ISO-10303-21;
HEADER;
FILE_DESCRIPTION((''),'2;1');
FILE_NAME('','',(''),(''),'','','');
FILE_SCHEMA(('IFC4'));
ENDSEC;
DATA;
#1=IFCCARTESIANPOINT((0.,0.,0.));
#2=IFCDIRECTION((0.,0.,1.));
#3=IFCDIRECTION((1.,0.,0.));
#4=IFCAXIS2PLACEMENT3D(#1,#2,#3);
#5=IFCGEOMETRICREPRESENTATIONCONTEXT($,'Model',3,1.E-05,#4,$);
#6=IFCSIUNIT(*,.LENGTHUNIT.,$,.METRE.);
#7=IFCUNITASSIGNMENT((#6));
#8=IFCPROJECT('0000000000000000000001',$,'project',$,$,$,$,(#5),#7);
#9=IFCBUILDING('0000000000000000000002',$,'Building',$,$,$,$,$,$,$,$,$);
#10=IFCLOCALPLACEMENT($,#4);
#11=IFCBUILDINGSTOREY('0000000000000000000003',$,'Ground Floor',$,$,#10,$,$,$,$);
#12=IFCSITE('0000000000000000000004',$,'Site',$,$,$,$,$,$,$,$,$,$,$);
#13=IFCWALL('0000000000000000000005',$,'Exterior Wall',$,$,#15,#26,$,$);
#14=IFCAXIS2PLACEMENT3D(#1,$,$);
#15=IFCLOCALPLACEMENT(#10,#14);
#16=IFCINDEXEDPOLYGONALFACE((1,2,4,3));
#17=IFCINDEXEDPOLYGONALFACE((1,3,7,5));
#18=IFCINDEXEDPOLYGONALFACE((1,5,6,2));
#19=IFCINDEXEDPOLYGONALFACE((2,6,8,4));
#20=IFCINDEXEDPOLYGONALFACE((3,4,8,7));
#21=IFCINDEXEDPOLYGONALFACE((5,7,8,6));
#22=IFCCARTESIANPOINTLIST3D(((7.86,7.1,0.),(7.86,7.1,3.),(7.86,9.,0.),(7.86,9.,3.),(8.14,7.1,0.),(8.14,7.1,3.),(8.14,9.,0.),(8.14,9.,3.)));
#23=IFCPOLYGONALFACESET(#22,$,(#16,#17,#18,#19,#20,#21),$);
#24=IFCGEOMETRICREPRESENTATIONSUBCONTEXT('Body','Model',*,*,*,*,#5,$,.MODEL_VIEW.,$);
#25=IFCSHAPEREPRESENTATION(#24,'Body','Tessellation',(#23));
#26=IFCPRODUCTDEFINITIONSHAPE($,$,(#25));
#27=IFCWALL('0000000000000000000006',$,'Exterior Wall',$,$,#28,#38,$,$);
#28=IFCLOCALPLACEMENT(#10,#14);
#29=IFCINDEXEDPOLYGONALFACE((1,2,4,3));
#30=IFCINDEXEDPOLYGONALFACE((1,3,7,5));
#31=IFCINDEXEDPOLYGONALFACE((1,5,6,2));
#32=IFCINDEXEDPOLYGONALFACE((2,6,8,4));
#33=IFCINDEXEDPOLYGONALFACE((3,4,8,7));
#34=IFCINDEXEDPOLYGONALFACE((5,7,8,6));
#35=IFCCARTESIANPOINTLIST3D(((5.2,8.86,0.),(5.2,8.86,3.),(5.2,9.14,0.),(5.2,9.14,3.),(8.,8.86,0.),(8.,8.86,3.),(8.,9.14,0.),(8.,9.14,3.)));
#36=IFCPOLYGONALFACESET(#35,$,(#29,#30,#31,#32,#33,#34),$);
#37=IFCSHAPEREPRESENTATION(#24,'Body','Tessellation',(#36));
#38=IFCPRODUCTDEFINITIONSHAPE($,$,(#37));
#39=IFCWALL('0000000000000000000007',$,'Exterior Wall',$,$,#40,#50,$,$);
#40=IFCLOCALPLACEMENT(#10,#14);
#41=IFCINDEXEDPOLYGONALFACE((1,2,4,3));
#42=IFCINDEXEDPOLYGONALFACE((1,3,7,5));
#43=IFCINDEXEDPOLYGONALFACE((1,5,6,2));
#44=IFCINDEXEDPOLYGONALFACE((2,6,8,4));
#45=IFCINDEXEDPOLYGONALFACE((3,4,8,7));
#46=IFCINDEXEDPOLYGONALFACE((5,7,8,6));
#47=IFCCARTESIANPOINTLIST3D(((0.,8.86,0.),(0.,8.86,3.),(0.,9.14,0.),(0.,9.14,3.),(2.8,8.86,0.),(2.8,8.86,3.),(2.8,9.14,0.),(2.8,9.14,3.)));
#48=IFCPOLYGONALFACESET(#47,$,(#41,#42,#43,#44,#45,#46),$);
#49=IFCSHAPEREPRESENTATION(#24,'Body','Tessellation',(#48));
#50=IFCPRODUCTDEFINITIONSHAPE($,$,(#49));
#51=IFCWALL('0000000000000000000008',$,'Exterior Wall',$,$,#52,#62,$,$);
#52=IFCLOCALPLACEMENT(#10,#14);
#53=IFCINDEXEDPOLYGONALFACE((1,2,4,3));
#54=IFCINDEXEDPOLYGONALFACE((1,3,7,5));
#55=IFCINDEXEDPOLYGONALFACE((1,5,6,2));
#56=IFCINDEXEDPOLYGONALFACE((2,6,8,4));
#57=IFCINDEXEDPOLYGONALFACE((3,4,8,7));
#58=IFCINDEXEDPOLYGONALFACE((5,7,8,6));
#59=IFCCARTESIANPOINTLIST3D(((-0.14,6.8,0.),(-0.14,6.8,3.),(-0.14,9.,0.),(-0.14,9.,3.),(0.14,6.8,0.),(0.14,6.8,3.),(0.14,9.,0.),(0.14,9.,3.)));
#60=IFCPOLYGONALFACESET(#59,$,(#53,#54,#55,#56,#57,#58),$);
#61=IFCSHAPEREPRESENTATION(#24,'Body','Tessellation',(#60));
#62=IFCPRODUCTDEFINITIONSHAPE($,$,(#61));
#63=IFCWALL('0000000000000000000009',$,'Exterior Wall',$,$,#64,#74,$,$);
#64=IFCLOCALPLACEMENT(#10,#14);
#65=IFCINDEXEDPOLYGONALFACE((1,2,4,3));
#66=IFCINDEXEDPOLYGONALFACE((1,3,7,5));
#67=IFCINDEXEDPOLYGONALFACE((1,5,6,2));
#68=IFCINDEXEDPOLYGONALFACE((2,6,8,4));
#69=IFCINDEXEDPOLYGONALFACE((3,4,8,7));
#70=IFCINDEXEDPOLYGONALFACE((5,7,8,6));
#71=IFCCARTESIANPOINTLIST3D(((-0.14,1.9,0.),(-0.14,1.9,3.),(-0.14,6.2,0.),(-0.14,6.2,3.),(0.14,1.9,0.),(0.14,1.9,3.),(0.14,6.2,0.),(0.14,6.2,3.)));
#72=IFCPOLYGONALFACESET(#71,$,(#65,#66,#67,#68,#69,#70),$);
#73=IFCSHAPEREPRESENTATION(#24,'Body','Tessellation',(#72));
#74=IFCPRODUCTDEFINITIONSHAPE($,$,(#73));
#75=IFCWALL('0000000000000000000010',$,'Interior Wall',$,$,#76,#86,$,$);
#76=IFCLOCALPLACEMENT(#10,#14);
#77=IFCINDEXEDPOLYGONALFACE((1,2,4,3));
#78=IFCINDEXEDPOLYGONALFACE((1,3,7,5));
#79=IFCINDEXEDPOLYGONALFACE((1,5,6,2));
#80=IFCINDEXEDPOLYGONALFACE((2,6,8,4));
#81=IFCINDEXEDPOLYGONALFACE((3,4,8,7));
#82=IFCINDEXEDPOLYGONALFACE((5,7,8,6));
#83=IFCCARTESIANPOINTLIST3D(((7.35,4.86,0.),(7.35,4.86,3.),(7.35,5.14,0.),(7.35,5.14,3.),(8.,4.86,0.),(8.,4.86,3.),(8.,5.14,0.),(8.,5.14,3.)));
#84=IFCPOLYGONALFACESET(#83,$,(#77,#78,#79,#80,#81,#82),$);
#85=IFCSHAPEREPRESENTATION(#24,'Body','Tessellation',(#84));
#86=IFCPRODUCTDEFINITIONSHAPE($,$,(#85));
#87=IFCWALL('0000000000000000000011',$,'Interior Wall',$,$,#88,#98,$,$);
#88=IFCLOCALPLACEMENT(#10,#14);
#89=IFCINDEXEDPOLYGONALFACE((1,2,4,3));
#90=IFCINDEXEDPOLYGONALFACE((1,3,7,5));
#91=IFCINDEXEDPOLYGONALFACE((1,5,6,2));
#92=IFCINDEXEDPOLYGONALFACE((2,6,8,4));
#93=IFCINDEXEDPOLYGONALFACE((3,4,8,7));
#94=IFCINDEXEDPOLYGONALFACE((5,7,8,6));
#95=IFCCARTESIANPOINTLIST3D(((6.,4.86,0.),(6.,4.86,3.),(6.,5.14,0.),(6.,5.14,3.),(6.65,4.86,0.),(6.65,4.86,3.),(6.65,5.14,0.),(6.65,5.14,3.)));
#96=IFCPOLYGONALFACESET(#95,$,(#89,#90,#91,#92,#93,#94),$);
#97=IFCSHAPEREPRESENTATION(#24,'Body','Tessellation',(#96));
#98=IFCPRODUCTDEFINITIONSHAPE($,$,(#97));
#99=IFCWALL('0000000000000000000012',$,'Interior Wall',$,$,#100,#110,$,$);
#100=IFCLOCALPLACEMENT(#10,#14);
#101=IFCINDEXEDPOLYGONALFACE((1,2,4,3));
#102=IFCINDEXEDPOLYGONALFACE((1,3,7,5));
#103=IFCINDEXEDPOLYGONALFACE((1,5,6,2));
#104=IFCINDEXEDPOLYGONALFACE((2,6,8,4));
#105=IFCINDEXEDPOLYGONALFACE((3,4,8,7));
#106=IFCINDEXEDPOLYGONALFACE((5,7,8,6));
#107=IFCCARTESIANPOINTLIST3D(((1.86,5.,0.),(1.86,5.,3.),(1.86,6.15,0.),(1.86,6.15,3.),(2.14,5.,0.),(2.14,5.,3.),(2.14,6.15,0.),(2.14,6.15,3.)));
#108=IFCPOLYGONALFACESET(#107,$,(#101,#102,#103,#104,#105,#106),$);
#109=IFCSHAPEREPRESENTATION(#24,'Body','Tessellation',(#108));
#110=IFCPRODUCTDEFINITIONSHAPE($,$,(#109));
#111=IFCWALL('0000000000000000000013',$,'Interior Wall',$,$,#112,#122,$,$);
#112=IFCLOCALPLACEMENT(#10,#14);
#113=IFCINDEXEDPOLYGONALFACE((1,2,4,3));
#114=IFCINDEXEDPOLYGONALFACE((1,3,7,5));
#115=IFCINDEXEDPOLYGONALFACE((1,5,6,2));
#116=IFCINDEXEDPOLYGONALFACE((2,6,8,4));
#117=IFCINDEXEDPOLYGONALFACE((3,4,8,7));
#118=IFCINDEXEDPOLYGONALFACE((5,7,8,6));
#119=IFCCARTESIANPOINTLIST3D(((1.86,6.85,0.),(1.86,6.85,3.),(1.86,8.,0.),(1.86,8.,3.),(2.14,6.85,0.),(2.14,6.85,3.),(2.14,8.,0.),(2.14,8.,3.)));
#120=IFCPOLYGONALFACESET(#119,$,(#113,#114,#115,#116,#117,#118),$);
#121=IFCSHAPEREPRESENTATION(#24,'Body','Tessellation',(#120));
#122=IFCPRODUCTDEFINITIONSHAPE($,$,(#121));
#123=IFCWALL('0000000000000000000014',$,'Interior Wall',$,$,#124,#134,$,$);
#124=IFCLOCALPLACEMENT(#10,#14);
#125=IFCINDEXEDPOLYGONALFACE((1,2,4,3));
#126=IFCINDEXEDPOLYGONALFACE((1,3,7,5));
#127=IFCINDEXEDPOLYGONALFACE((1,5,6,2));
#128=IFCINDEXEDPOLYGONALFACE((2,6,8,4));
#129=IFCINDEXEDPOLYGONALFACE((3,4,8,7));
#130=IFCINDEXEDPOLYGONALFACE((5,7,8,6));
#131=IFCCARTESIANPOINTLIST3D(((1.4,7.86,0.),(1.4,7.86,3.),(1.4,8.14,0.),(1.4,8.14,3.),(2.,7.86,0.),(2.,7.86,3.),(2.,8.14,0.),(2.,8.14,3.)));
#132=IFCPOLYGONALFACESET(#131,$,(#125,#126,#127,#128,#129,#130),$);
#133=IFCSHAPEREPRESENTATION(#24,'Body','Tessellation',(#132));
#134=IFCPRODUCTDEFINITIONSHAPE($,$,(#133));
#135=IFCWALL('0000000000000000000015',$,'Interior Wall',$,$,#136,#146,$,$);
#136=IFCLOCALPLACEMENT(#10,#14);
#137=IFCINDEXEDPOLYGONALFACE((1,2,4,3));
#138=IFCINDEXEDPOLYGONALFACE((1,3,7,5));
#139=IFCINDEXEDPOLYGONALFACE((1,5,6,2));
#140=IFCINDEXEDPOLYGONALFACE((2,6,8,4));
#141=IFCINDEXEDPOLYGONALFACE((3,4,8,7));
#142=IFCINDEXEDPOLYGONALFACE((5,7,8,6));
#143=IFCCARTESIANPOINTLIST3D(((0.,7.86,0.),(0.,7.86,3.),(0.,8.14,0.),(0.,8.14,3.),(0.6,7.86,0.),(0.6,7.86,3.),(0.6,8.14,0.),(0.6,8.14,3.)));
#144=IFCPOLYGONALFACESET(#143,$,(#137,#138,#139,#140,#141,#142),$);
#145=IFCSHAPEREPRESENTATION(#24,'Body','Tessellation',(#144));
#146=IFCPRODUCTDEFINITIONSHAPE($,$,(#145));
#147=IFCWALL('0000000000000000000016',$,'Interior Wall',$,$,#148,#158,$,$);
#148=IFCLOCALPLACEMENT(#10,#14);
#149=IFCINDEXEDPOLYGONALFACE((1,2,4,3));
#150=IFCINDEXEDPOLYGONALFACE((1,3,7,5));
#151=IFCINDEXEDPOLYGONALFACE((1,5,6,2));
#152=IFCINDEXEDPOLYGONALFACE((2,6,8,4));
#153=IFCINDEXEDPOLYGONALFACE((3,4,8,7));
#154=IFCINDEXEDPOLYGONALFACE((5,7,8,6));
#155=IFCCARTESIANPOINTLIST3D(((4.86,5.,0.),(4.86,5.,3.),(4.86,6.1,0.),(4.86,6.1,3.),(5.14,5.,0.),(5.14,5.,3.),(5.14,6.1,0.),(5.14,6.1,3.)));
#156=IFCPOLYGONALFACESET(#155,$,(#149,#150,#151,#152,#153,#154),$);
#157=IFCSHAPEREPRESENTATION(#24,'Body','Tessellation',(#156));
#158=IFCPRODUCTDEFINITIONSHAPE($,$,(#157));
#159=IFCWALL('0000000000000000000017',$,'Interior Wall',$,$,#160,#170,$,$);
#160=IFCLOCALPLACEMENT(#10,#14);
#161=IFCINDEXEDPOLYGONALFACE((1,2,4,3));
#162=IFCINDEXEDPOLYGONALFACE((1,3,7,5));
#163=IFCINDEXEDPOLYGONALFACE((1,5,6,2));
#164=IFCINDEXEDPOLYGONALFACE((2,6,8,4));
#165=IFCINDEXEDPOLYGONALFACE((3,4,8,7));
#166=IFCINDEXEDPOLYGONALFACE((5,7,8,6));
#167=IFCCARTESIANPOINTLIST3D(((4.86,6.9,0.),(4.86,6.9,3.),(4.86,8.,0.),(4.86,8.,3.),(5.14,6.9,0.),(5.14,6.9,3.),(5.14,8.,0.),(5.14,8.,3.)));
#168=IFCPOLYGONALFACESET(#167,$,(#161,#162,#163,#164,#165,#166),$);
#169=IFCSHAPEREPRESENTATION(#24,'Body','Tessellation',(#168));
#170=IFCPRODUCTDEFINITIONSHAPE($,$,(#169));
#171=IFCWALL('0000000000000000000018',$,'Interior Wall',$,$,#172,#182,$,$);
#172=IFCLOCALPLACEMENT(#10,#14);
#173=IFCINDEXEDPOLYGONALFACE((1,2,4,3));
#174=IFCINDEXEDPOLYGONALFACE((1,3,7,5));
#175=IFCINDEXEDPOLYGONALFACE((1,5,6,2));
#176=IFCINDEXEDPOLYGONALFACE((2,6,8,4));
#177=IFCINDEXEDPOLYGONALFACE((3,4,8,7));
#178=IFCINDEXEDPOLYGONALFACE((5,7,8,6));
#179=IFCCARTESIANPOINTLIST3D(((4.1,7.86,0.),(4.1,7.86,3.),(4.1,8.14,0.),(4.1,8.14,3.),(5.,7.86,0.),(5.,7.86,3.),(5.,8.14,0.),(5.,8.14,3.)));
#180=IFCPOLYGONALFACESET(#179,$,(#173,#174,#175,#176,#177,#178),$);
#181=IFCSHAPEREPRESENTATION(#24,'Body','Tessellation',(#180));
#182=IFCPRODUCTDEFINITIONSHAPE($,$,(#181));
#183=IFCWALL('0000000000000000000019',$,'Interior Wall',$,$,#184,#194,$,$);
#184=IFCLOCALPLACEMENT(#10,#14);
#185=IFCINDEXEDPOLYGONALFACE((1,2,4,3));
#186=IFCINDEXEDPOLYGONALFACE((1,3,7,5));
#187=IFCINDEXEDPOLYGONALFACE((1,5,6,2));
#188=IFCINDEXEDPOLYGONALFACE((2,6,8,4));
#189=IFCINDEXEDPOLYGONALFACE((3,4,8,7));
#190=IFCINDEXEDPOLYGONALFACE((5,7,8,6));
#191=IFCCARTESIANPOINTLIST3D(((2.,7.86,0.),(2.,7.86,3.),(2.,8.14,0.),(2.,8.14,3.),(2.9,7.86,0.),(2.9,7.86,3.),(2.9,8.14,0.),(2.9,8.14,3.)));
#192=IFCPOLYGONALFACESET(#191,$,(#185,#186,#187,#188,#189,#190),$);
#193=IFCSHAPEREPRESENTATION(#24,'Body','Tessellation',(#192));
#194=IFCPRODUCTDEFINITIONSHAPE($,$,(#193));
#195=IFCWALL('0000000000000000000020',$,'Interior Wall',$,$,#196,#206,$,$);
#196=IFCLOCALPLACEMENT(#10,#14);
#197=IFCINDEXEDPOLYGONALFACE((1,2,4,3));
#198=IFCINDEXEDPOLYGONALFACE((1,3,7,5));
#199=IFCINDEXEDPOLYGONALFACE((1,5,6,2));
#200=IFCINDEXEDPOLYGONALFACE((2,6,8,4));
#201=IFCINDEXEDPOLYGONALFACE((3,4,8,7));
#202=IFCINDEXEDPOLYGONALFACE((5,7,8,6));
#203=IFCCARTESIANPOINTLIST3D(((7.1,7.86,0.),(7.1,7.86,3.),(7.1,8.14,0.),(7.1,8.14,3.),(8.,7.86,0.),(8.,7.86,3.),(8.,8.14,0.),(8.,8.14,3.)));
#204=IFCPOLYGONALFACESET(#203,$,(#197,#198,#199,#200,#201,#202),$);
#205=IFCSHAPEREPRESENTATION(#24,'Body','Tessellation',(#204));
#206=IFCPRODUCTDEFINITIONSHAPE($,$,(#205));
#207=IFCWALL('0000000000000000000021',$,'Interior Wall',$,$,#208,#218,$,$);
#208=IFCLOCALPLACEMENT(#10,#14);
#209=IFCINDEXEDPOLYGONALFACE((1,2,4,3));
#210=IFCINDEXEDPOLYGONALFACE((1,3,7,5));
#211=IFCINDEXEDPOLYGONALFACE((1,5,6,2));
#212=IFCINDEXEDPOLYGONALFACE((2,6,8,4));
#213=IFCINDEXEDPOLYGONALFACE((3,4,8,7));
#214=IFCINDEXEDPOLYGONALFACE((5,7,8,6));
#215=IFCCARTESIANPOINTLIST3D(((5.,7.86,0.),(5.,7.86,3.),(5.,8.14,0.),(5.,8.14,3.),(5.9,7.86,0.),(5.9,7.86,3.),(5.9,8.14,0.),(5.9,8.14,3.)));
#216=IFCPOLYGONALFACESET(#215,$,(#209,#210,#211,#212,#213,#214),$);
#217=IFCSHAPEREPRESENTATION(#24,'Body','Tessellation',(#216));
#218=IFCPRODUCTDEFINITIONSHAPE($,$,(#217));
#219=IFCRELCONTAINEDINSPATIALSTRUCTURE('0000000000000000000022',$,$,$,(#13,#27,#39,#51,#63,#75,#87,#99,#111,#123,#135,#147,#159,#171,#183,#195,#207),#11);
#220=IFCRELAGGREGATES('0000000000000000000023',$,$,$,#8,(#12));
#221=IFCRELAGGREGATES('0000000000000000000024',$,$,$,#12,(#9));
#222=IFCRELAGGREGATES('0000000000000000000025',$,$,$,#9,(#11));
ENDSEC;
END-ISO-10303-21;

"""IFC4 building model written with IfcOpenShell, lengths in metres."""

from ifc_helpers import new_model, si_unit, frame, origin_with_axes, place, context, subcontext, project, spatial, indexed_curve, outline, extrude, element, save


model = new_model("IFC4")

# Units and contexts
model_context = context("Model", 3, precision=1e-05, world=origin_with_axes())
body_context = subcontext(model_context, "Body", "Model", "MODEL_VIEW")
ifc_project = project(units=[si_unit("LENGTHUNIT", "METRE")], contexts=[model_context])

# Site, building, storey
site = spatial("IfcSite", under=ifc_project, Name="Site")
building = spatial("IfcBuilding", under=site, Name="Building")
storey_placement = place(None, origin_with_axes())
storey = spatial("IfcBuildingStorey", under=building, at=storey_placement, Name="Ground Floor")

# Walls
wall_1_placement = place(storey_placement, frame((8.0, 7.1, 0.0), z_axis=(0.0, 0.0, 1.0), x_axis=(0.0, 1.0, 0.0)))
element("IfcWall", 1, at=wall_1_placement, inside=storey, Name="Exterior Wall", context=body_context, shape_type="SweptSolid", body=[
    extrude(outline(indexed_curve([(0.0, 0.0), (0.0, 0.28), (1.9, 0.28), (1.9, 0.0), (0.0, 0.0)], self_intersect=False)), frame((0.0, -0.14, 0.0), z_axis=(0.0, 0.0, 1.0), x_axis=(1.0, 0.0, 0.0)), (0.0, 0.0, 1.0), 3.0),
])
for number, where, z_axis, x_axis, name in (
    (2, (8.0, 9.0, 0.0), (0.0, 0.0, 1.0), (-1.0, 0.0, 0.0), "Exterior Wall"),
    (3, (2.8, 9.0, 0.0), (0.0, 0.0, 1.0), (-1.0, 0.0, 0.0), "Exterior Wall"),
):
    element("IfcWall", number, at=place(storey_placement, frame(where, z_axis=z_axis, x_axis=x_axis)), inside=storey, Name=name, context=body_context, shape_type="SweptSolid", body=[
        extrude(outline(indexed_curve([(0.0, 0.0), (0.0, 0.28), (2.8, 0.28), (2.8, 0.0), (0.0, 0.0)], self_intersect=False)), frame((0.0, -0.14, 0.0), z_axis=(0.0, 0.0, 1.0), x_axis=(1.0, 0.0, 0.0)), (0.0, 0.0, 1.0), 3.0),
    ])
wall_2_placement = place(storey_placement, frame((0.0, 9.0, 0.0), z_axis=(0.0, 0.0, 1.0), x_axis=(0.0, -1.0, 0.0)))
element("IfcWall", 4, at=wall_2_placement, inside=storey, Name="Exterior Wall", context=body_context, shape_type="SweptSolid", body=[
    extrude(outline(indexed_curve([(0.0, 0.0), (0.0, 0.28), (2.2, 0.28), (2.2, 0.0), (0.0, 0.0)], self_intersect=False)), frame((0.0, -0.14, 0.0), z_axis=(0.0, 0.0, 1.0), x_axis=(1.0, 0.0, 0.0)), (0.0, 0.0, 1.0), 3.0),
])
wall_3_placement = place(storey_placement, frame((0.0, 6.2, 0.0), z_axis=(0.0, 0.0, 1.0), x_axis=(0.0, -1.0, 0.0)))
element("IfcWall", 5, at=wall_3_placement, inside=storey, Name="Exterior Wall", context=body_context, shape_type="SweptSolid", body=[
    extrude(outline(indexed_curve([(0.0, 0.0), (0.0, 0.28), (4.3, 0.28), (4.3, 0.0), (0.0, 0.0)], self_intersect=False)), frame((0.0, -0.14, 0.0), z_axis=(0.0, 0.0, 1.0), x_axis=(1.0, 0.0, 0.0)), (0.0, 0.0, 1.0), 3.0),
])
for number, where, z_axis, x_axis, name in (
    (6, (8.0, 5.0, 0.0), (0.0, 0.0, 1.0), (-1.0, 0.0, 0.0), "Interior Wall"),
    (7, (6.65, 5.0, 0.0), (0.0, 0.0, 1.0), (-1.0, 0.0, 0.0), "Interior Wall"),
):
    element("IfcWall", number, at=place(storey_placement, frame(where, z_axis=z_axis, x_axis=x_axis)), inside=storey, Name=name, context=body_context, shape_type="SweptSolid", body=[
        extrude(outline(indexed_curve([(0.0, 0.0), (0.0, 0.28), (0.65, 0.28), (0.65, 0.0), (0.0, 0.0)], self_intersect=False)), frame((0.0, -0.14, 0.0), z_axis=(0.0, 0.0, 1.0), x_axis=(1.0, 0.0, 0.0)), (0.0, 0.0, 1.0), 3.0),
    ])
for number, where, z_axis, x_axis, name in (
    (8, (2.0, 5.0, 0.0), (0.0, 0.0, 1.0), (0.0, 1.0, 0.0), "Interior Wall"),
    (9, (2.0, 6.85, 0.0), (0.0, 0.0, 1.0), (0.0, 1.0, 0.0), "Interior Wall"),
):
    element("IfcWall", number, at=place(storey_placement, frame(where, z_axis=z_axis, x_axis=x_axis)), inside=storey, Name=name, context=body_context, shape_type="SweptSolid", body=[
        extrude(outline(indexed_curve([(0.0, 0.0), (0.0, 0.28), (1.15, 0.28), (1.15, 0.0), (0.0, 0.0)], self_intersect=False)), frame((0.0, -0.14, 0.0), z_axis=(0.0, 0.0, 1.0), x_axis=(1.0, 0.0, 0.0)), (0.0, 0.0, 1.0), 3.0),
    ])
for number, where, z_axis, x_axis, name in (
    (10, (2.0, 8.0, 0.0), (0.0, 0.0, 1.0), (-1.0, 0.0, 0.0), "Interior Wall"),
    (11, (0.6, 8.0, 0.0), (0.0, 0.0, 1.0), (-1.0, 0.0, 0.0), "Interior Wall"),
):
    element("IfcWall", number, at=place(storey_placement, frame(where, z_axis=z_axis, x_axis=x_axis)), inside=storey, Name=name, context=body_context, shape_type="SweptSolid", body=[
        extrude(outline(indexed_curve([(0.0, 0.0), (0.0, 0.28), (0.6, 0.28), (0.6, 0.0), (0.0, 0.0)], self_intersect=False)), frame((0.0, -0.14, 0.0), z_axis=(0.0, 0.0, 1.0), x_axis=(1.0, 0.0, 0.0)), (0.0, 0.0, 1.0), 3.0),
    ])
for number, where, z_axis, x_axis, name in (
    (12, (5.0, 5.0, 0.0), (0.0, 0.0, 1.0), (0.0, 1.0, 0.0), "Interior Wall"),
    (13, (5.0, 6.9, 0.0), (0.0, 0.0, 1.0), (0.0, 1.0, 0.0), "Interior Wall"),
):
    element("IfcWall", number, at=place(storey_placement, frame(where, z_axis=z_axis, x_axis=x_axis)), inside=storey, Name=name, context=body_context, shape_type="SweptSolid", body=[
        extrude(outline(indexed_curve([(0.0, 0.0), (0.0, 0.28), (1.1, 0.28), (1.1, 0.0), (0.0, 0.0)], self_intersect=False)), frame((0.0, -0.14, 0.0), z_axis=(0.0, 0.0, 1.0), x_axis=(1.0, 0.0, 0.0)), (0.0, 0.0, 1.0), 3.0),
    ])
wall_4_placement = place(storey_placement, frame((5.0, 8.0, 0.0), z_axis=(0.0, 0.0, 1.0), x_axis=(-1.0, 0.0, 0.0)))
element("IfcWall", 14, at=wall_4_placement, inside=storey, Name="Interior Wall", context=body_context, shape_type="SweptSolid", body=[
    extrude(outline(indexed_curve([(0.0, 0.0), (0.0, 0.28), (0.9, 0.28), (0.9, 0.0), (0.0, 0.0)], self_intersect=False)), frame((0.0, -0.14, 0.0), z_axis=(0.0, 0.0, 1.0), x_axis=(1.0, 0.0, 0.0)), (0.0, 0.0, 1.0), 3.0),
])
wall_5_placement = place(storey_placement, frame((2.9, 8.0, 0.0), z_axis=(0.0, 0.0, 1.0), x_axis=(-1.0, 0.0, 0.0)))
element("IfcWall", 15, at=wall_5_placement, inside=storey, Name="Interior Wall", context=body_context, shape_type="SweptSolid", body=[
    extrude(outline(indexed_curve([(0.0, 0.0), (0.0, 0.28), (0.9, 0.28), (0.9, 0.0), (0.0, 0.0)], self_intersect=False)), frame((0.0, -0.14, 0.0), z_axis=(0.0, 0.0, 1.0), x_axis=(1.0, 0.0, 0.0)), (0.0, 0.0, 1.0), 3.0),
])
for number, where, z_axis, x_axis, name in (
    (16, (8.0, 8.0, 0.0), (0.0, 0.0, 1.0), (-1.0, 0.0, 0.0), "Interior Wall"),
    (17, (5.9, 8.0, 0.0), (0.0, 0.0, 1.0), (-1.0, 0.0, 0.0), "Interior Wall"),
):
    element("IfcWall", number, at=place(storey_placement, frame(where, z_axis=z_axis, x_axis=x_axis)), inside=storey, Name=name, context=body_context, shape_type="SweptSolid", body=[
        extrude(outline(indexed_curve([(0.0, 0.0), (0.0, 0.28), (0.9, 0.28), (0.9, 0.0), (0.0, 0.0)], self_intersect=False)), frame((0.0, -0.14, 0.0), z_axis=(0.0, 0.0, 1.0), x_axis=(1.0, 0.0, 0.0)), (0.0, 0.0, 1.0), 3.0),
    ])

save(model, "model.ifc")
